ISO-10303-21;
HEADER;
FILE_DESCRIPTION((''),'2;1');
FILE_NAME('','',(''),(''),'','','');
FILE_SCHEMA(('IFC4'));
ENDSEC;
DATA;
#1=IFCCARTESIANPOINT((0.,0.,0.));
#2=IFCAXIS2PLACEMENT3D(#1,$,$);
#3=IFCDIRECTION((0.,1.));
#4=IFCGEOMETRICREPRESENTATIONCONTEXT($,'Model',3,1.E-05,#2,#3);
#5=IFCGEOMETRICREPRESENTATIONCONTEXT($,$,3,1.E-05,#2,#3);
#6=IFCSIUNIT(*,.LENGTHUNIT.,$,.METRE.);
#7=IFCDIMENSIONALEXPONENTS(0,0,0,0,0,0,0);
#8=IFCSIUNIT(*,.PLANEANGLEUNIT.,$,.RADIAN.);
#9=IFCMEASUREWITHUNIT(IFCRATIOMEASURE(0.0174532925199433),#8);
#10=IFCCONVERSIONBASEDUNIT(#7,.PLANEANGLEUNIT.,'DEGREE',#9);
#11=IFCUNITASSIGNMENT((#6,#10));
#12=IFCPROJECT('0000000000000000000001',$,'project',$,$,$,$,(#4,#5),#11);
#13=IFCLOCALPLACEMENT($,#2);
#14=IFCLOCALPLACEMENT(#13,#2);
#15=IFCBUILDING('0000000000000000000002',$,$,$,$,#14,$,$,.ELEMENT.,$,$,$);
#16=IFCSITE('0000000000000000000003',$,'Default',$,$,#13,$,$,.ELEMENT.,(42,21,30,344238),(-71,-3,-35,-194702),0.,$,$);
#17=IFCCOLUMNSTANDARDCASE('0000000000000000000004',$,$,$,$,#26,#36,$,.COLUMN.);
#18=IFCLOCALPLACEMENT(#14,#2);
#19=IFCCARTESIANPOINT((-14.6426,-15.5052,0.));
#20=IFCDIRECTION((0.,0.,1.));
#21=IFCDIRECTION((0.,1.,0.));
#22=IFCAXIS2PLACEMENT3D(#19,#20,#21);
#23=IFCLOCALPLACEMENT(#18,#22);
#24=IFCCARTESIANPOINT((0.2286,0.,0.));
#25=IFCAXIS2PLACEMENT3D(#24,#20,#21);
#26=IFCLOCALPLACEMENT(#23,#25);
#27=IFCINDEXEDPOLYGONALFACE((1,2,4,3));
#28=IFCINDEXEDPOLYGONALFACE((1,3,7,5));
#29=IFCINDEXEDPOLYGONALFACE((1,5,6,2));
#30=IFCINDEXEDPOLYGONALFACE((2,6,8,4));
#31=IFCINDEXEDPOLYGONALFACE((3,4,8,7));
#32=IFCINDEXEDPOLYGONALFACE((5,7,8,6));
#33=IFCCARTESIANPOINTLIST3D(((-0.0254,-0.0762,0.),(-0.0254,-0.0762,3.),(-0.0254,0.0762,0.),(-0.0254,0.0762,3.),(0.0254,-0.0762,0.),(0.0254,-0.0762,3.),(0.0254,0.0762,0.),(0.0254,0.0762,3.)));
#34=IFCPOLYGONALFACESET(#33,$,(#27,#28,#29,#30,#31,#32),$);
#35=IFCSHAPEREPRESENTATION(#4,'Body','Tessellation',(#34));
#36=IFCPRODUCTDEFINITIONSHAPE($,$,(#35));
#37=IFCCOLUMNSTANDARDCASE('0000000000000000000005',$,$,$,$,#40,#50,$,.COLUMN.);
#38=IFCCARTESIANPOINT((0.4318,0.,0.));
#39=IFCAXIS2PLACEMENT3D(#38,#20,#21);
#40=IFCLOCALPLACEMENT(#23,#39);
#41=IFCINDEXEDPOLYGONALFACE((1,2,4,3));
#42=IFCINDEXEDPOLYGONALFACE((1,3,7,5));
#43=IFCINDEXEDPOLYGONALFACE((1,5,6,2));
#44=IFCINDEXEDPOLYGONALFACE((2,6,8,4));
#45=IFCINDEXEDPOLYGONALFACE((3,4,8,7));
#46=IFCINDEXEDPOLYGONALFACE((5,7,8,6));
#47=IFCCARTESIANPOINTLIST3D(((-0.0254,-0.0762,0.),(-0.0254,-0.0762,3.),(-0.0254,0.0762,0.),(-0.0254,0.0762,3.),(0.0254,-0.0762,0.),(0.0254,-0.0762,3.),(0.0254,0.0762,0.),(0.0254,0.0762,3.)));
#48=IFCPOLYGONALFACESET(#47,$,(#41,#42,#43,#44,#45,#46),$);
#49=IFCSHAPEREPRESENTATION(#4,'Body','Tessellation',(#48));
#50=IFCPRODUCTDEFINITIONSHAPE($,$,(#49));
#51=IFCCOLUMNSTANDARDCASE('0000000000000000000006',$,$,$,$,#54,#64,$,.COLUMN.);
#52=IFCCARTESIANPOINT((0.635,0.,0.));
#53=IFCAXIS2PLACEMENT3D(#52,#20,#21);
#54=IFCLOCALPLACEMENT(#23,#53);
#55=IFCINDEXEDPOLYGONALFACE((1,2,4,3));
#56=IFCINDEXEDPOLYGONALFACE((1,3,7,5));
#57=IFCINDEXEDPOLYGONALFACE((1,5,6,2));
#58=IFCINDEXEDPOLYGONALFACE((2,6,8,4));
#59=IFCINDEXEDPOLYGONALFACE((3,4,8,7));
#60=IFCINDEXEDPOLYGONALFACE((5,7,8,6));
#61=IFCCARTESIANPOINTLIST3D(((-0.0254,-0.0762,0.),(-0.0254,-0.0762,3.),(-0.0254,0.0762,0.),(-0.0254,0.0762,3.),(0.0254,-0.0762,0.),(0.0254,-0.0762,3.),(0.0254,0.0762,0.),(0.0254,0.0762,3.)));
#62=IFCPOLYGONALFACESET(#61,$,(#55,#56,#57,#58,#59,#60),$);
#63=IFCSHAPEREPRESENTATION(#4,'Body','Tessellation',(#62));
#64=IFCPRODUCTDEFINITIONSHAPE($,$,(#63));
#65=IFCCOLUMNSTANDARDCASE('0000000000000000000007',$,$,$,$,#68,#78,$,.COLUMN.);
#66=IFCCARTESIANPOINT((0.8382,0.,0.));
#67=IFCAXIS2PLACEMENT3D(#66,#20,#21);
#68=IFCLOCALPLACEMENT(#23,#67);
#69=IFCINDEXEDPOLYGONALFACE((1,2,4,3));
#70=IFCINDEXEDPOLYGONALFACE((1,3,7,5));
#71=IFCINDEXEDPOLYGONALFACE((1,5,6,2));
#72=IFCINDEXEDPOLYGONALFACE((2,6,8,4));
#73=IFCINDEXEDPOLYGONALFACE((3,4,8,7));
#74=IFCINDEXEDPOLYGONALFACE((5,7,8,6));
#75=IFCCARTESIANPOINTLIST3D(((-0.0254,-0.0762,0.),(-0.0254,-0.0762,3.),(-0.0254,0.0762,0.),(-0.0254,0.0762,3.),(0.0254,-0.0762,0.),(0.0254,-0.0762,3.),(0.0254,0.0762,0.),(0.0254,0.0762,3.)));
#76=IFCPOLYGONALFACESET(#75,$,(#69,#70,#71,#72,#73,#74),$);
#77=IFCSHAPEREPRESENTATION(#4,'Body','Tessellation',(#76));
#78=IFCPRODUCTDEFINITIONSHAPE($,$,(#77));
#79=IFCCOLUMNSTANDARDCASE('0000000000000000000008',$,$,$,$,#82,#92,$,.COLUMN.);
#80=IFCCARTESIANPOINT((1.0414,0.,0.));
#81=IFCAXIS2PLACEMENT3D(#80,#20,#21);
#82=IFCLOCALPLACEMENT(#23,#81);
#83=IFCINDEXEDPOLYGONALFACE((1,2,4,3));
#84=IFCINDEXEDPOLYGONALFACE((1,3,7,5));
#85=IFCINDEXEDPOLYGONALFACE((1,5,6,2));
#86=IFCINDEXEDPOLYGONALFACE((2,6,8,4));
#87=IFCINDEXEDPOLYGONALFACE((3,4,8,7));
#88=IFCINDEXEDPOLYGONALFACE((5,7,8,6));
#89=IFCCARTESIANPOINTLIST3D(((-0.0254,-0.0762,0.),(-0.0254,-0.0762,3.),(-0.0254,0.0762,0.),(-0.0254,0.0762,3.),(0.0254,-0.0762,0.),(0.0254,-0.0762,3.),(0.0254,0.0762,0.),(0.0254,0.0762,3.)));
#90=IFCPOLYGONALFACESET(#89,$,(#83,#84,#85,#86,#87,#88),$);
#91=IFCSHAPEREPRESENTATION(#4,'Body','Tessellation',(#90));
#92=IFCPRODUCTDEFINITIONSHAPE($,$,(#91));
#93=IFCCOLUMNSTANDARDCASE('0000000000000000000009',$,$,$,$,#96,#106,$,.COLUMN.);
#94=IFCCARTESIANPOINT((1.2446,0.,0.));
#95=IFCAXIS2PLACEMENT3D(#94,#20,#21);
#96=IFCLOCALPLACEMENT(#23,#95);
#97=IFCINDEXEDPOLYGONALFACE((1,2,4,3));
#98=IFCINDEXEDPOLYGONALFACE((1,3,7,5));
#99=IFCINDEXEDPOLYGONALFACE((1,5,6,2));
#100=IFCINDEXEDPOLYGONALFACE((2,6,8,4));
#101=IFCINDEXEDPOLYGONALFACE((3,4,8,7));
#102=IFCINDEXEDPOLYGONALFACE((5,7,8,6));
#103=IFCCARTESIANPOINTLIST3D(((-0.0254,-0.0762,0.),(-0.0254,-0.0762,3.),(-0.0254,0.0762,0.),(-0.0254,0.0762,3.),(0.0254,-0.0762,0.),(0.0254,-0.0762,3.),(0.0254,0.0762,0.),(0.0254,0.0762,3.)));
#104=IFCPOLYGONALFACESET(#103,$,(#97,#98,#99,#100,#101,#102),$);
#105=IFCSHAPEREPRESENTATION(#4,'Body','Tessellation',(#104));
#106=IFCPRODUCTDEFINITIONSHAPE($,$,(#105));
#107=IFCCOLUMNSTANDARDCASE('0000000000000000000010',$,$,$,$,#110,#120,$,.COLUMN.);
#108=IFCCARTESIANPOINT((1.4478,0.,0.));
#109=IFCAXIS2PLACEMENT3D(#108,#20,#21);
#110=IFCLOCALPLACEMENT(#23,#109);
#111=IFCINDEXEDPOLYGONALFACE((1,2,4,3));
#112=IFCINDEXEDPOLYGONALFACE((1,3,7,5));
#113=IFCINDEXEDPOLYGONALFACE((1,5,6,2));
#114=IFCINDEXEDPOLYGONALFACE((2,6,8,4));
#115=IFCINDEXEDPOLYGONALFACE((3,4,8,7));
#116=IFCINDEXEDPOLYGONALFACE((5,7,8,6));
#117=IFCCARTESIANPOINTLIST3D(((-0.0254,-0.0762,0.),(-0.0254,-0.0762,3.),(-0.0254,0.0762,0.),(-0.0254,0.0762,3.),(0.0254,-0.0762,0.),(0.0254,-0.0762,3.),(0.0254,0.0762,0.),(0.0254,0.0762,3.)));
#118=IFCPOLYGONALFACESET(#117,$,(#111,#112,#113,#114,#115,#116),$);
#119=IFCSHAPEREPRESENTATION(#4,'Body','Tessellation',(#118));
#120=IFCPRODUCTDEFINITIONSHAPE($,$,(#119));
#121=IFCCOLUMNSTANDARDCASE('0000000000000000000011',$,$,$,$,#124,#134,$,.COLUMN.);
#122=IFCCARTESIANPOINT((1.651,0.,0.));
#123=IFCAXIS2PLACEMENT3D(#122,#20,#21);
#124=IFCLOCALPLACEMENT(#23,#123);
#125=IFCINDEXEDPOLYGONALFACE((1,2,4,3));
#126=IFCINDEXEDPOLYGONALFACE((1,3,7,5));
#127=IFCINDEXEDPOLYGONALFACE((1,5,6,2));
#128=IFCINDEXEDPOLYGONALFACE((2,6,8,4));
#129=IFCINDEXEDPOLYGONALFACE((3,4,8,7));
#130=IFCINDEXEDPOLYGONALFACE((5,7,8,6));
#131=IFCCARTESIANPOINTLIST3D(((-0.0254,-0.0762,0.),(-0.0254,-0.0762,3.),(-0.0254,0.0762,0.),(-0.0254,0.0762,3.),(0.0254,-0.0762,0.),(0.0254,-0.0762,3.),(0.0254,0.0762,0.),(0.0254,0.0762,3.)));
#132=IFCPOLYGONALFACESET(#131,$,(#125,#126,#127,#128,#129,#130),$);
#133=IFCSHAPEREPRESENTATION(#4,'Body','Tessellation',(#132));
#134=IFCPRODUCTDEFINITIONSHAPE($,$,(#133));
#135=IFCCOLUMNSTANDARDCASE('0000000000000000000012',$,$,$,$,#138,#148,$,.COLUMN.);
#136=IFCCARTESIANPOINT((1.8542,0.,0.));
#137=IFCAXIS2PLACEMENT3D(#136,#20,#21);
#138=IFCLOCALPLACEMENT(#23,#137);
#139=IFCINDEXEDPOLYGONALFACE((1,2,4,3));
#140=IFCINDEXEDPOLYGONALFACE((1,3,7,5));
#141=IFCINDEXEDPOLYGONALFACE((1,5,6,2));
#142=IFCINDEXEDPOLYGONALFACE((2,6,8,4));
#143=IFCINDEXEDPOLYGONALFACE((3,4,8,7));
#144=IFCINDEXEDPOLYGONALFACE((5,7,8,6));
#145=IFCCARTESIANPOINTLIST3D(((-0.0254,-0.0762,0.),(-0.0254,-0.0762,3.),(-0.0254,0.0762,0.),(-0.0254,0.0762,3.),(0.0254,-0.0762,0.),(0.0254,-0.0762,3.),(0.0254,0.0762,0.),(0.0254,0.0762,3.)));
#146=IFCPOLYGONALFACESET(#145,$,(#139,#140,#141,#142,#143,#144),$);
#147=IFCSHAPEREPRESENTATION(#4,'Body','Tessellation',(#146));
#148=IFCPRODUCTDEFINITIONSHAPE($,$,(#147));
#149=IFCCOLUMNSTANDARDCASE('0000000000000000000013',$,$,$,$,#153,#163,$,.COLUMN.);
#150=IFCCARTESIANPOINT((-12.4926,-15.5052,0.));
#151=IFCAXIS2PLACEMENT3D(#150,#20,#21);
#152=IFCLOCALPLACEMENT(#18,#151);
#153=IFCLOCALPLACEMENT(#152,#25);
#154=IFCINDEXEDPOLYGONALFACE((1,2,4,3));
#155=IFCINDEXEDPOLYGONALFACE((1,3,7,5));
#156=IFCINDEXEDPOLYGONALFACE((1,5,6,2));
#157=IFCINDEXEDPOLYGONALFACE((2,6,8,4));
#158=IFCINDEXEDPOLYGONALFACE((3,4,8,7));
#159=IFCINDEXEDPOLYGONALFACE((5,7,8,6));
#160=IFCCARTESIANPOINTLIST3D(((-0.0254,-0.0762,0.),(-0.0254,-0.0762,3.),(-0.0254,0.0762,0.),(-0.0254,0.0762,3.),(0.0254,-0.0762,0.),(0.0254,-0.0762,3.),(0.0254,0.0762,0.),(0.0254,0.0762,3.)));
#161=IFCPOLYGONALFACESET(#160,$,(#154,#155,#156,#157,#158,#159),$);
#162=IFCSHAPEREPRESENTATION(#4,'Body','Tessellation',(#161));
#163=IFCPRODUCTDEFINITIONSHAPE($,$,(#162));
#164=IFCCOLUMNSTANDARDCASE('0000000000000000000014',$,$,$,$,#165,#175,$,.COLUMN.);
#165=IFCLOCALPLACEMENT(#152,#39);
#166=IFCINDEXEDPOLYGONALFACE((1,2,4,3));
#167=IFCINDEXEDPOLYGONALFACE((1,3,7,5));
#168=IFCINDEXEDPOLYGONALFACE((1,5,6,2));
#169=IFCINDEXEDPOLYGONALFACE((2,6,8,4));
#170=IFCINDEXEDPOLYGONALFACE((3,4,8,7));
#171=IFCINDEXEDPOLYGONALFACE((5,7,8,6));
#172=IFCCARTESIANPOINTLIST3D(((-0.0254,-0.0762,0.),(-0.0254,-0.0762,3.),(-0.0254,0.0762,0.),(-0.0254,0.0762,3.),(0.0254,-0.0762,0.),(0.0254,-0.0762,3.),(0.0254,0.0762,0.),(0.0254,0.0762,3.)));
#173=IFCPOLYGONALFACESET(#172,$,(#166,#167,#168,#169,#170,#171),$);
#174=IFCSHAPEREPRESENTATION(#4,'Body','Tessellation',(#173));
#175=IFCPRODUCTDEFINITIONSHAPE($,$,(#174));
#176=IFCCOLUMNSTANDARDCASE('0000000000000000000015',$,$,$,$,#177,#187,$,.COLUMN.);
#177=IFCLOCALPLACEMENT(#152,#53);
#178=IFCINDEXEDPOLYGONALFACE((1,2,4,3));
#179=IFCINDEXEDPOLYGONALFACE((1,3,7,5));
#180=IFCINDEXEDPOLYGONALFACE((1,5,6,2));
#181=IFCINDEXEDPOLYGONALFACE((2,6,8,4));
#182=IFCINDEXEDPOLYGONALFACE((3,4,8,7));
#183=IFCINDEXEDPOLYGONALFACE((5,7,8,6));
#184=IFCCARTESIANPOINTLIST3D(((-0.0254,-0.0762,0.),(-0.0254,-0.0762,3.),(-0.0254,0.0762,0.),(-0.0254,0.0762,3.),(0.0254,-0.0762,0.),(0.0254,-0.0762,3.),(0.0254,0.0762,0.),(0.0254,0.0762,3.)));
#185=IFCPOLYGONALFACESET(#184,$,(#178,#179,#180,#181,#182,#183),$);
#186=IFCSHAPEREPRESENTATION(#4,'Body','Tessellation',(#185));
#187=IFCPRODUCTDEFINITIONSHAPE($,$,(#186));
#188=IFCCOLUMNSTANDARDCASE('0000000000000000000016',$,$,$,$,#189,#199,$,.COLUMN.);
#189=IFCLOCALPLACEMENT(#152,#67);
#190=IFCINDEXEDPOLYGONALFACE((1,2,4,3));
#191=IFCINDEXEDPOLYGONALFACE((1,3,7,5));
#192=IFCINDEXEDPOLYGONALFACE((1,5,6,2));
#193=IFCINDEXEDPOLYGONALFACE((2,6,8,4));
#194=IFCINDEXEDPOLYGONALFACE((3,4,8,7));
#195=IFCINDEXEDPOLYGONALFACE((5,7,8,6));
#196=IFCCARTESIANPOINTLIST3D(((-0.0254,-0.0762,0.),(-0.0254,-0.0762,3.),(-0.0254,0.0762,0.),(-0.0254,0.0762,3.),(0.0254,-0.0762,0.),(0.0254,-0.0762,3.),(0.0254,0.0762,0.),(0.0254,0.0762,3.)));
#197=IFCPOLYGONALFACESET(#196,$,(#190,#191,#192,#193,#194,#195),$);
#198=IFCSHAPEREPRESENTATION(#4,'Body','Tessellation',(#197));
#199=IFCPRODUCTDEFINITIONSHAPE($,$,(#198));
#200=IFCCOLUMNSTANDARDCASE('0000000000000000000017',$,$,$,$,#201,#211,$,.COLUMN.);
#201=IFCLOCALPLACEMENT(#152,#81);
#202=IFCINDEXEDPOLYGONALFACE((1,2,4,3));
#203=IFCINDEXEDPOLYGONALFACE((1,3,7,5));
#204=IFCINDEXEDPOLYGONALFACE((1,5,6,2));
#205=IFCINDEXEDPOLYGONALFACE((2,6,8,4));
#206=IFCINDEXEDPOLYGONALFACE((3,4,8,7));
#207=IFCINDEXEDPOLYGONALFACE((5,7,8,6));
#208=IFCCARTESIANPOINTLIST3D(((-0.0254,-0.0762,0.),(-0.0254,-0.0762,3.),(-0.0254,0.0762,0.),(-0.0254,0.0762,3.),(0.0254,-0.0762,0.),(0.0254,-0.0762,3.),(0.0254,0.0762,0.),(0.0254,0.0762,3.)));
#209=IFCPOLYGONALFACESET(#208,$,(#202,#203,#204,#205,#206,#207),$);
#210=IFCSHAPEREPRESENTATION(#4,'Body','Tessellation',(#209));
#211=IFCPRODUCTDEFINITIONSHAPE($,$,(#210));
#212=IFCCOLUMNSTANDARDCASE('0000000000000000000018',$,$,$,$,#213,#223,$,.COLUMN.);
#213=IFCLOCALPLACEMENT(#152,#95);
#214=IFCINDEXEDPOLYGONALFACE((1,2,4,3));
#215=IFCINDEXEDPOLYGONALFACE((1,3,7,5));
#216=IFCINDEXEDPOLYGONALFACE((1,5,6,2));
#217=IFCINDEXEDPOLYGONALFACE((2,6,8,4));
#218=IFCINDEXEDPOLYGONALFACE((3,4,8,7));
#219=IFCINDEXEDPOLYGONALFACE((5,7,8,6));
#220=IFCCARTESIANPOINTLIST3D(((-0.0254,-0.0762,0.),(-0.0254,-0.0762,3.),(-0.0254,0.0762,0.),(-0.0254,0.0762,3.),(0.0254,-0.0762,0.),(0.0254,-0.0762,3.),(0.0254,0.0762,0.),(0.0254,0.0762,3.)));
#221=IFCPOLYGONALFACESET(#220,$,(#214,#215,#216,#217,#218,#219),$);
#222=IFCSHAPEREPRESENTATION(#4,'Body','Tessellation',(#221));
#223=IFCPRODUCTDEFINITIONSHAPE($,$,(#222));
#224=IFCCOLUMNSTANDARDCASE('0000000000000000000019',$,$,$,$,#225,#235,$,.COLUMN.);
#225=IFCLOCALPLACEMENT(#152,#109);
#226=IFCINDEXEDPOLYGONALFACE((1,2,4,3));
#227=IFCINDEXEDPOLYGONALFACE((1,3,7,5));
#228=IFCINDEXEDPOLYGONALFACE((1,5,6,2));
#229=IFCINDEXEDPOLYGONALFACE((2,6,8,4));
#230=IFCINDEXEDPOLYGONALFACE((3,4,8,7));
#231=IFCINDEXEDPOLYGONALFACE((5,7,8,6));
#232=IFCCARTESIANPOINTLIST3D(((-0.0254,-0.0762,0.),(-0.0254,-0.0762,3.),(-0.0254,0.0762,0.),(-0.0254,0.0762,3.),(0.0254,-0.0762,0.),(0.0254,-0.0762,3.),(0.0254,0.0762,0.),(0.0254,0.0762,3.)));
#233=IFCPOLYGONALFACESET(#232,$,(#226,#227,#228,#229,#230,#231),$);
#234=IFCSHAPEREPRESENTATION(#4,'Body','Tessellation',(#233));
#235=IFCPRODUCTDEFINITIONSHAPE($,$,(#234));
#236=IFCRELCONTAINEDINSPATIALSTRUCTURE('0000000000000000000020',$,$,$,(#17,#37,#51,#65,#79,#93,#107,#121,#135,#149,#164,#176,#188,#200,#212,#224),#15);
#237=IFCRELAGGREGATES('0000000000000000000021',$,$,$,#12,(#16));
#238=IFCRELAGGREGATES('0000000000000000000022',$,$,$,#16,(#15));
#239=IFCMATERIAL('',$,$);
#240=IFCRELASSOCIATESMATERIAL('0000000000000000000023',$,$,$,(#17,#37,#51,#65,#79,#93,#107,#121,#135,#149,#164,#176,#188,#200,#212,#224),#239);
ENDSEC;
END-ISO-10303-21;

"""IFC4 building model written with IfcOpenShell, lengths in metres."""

from ifc_helpers import new_model, entity, si_unit, converted_unit, direction, frame, origin, place, context, project, spatial, rectangle, extrude, material, element, save


model = new_model("IFC4")

# Units and contexts
model_context = context("Model", 3, precision=1e-05, world=origin(), true_north=direction((0.0, 1.0)))
context_of_model = context(None, 3, precision=1e-05, world=origin(), true_north=direction((0.0, 1.0)))
ifc_project = project(units=[si_unit("LENGTHUNIT", "METRE"), converted_unit("PLANEANGLEUNIT", "DEGREE", entity("IfcRatioMeasure", 0.0174532925199433), si_unit("PLANEANGLEUNIT", "RADIAN"), dimensions=[0, 0, 0, 0, 0, 0, 0])], contexts=[model_context, context_of_model])

# Site, building
site_placement = place(None, origin())
site = spatial("IfcSite", under=ifc_project, at=site_placement, Name="Default", CompositionType="ELEMENT", RefLatitude=(42, 21, 30, 344238), RefLongitude=(-71, -3, -35, -194702), RefElevation=0.0)
building_placement = place(site_placement, origin())
building = spatial("IfcBuilding", under=site, at=building_placement, CompositionType="ELEMENT")

# Columns
ifc_material_1 = material(Name="")
placement_1 = place(building_placement, origin())
placement_2 = place(placement_1, frame((-14.6426, -15.5052, 0.0), z_axis=(0.0, 0.0, 1.0), x_axis=(0.0, 1.0, 0.0)))
for number, where, z_axis, x_axis in (
    (1, (0.2286, 0.0, 0.0), (0.0, 0.0, 1.0), (0.0, 1.0, 0.0)),
    (2, (0.4318, 0.0, 0.0), (0.0, 0.0, 1.0), (0.0, 1.0, 0.0)),
    (3, (0.635, 0.0, 0.0), (0.0, 0.0, 1.0), (0.0, 1.0, 0.0)),
    (4, (0.8382, 0.0, 0.0), (0.0, 0.0, 1.0), (0.0, 1.0, 0.0)),
    (5, (1.0414, 0.0, 0.0), (0.0, 0.0, 1.0), (0.0, 1.0, 0.0)),
    (6, (1.2446, 0.0, 0.0), (0.0, 0.0, 1.0), (0.0, 1.0, 0.0)),
    (7, (1.4478, 0.0, 0.0), (0.0, 0.0, 1.0), (0.0, 1.0, 0.0)),
    (8, (1.651, 0.0, 0.0), (0.0, 0.0, 1.0), (0.0, 1.0, 0.0)),
    (9, (1.8542, 0.0, 0.0), (0.0, 0.0, 1.0), (0.0, 1.0, 0.0)),
):
    element("IfcColumnStandardCase", number, at=place(placement_2, frame(where, z_axis=z_axis, x_axis=x_axis)), inside=building, material=ifc_material_1, PredefinedType="COLUMN", context=model_context, shape_type="SweptSolid", body=[
        extrude(rectangle(XDim=0.0508, YDim=0.1524), origin(), (0.0, 0.0, 1.0), 3.0),
    ])
placement_3 = place(placement_1, frame((-12.4926, -15.5052, 0.0), z_axis=(0.0, 0.0, 1.0), x_axis=(0.0, 1.0, 0.0)))
for number, where, z_axis, x_axis in (
    (10, (0.2286, 0.0, 0.0), (0.0, 0.0, 1.0), (0.0, 1.0, 0.0)),
    (11, (0.4318, 0.0, 0.0), (0.0, 0.0, 1.0), (0.0, 1.0, 0.0)),
    (12, (0.635, 0.0, 0.0), (0.0, 0.0, 1.0), (0.0, 1.0, 0.0)),
    (13, (0.8382, 0.0, 0.0), (0.0, 0.0, 1.0), (0.0, 1.0, 0.0)),
    (14, (1.0414, 0.0, 0.0), (0.0, 0.0, 1.0), (0.0, 1.0, 0.0)),
    (15, (1.2446, 0.0, 0.0), (0.0, 0.0, 1.0), (0.0, 1.0, 0.0)),
    (16, (1.4478, 0.0, 0.0), (0.0, 0.0, 1.0), (0.0, 1.0, 0.0)),
):
    element("IfcColumnStandardCase", number, at=place(placement_3, frame(where, z_axis=z_axis, x_axis=x_axis)), inside=building, material=ifc_material_1, PredefinedType="COLUMN", context=model_context, shape_type="SweptSolid", body=[
        extrude(rectangle(XDim=0.0508, YDim=0.1524), origin(), (0.0, 0.0, 1.0), 3.0),
    ])

save(model, "model.ifc")
